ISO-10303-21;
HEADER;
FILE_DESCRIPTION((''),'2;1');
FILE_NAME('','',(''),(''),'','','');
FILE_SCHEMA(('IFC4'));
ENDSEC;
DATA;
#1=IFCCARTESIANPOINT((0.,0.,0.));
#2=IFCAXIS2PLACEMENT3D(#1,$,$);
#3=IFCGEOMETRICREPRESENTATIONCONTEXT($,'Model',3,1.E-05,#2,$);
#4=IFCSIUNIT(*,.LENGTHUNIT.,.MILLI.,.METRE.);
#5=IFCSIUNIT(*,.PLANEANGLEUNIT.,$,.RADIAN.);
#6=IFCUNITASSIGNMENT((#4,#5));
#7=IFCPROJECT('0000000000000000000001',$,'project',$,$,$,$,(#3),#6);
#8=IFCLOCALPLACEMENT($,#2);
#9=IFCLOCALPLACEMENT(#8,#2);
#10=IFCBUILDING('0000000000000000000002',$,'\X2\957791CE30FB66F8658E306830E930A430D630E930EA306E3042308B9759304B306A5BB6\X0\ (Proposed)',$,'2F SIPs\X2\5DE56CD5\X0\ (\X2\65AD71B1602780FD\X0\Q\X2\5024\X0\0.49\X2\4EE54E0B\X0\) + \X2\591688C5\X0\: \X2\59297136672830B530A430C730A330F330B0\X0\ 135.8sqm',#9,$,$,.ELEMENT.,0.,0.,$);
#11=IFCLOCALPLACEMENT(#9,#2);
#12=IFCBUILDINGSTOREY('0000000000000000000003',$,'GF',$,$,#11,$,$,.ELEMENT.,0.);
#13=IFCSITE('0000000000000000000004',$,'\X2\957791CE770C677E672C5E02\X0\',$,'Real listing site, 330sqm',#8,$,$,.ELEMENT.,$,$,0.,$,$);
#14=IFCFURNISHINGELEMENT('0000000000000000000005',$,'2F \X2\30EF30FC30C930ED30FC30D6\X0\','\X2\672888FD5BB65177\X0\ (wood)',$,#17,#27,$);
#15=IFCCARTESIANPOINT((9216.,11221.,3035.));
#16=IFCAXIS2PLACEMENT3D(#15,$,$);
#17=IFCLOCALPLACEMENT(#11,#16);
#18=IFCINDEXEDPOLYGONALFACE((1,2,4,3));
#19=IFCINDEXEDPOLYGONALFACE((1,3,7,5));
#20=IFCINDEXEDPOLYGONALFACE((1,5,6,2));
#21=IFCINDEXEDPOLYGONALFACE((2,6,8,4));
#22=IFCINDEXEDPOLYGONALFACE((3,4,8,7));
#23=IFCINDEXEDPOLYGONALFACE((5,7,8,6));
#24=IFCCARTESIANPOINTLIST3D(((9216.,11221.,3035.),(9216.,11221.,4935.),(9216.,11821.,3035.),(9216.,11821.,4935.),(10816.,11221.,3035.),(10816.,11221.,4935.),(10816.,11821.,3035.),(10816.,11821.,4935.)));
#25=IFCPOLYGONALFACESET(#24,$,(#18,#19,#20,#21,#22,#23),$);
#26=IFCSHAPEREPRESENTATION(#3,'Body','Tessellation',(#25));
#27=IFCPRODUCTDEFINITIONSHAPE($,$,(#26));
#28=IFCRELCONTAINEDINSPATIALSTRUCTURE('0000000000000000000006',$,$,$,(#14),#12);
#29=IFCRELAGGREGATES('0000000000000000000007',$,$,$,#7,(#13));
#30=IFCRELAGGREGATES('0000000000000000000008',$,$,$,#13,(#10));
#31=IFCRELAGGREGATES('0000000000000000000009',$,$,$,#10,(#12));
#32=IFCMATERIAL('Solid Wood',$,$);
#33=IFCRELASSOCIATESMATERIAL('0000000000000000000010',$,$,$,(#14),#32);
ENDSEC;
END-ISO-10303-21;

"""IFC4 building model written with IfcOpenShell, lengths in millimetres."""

from ifc_helpers import new_model, si_unit, frame, frame_2d, origin, place, context, project, spatial, rectangle, extrude, material, element, save


model = new_model("IFC4")

# Units and contexts
model_context = context("Model", 3, precision=1e-05, world=origin())
ifc_project = project(units=[si_unit("LENGTHUNIT", "METRE", prefix="MILLI"), si_unit("PLANEANGLEUNIT", "RADIAN")], contexts=[model_context])

# Site, building, storey
site_placement = place(None, origin())
site = spatial("IfcSite", under=ifc_project, at=site_placement, Name="長野県松本市", ObjectType="Real listing site, 330sqm", CompositionType="ELEMENT", RefElevation=0.0)
building_placement = place(site_placement, origin())
building = spatial("IfcBuilding", under=site, at=building_placement, Name="長野・書斎とライブラリのある静かな家 (Proposed)", ObjectType="2F SIPs工法 (断熱性能Q値0.49以下) + 外装: 天然木サイディング 135.8sqm", CompositionType="ELEMENT", ElevationOfRefHeight=0.0, ElevationOfTerrain=0.0)
storey_placement = place(building_placement, origin())
storey = spatial("IfcBuildingStorey", under=building, at=storey_placement, Name="GF", CompositionType="ELEMENT", Elevation=0.0)

# Shared definitions
ifc_material_1 = material(Name="Solid Wood")

# Furnishing element
furnishing_placement = place(storey_placement, frame((9216.0, 11221.0, 3035.0)))
element("IfcFurnishingElement", 1, at=furnishing_placement, inside=storey, material=ifc_material_1, Name="2F ワードローブ", Description="木製家具 (wood)", context=model_context, shape_type="SweptSolid", body=[
    extrude(rectangle(XDim=1600.0, YDim=600.0, at=frame_2d((800.0, 300.0))), frame((9216.0, 11221.0, 3035.0)), (0.0, 0.0, 1.0), 1900.0),
])

save(model, "model.ifc")
